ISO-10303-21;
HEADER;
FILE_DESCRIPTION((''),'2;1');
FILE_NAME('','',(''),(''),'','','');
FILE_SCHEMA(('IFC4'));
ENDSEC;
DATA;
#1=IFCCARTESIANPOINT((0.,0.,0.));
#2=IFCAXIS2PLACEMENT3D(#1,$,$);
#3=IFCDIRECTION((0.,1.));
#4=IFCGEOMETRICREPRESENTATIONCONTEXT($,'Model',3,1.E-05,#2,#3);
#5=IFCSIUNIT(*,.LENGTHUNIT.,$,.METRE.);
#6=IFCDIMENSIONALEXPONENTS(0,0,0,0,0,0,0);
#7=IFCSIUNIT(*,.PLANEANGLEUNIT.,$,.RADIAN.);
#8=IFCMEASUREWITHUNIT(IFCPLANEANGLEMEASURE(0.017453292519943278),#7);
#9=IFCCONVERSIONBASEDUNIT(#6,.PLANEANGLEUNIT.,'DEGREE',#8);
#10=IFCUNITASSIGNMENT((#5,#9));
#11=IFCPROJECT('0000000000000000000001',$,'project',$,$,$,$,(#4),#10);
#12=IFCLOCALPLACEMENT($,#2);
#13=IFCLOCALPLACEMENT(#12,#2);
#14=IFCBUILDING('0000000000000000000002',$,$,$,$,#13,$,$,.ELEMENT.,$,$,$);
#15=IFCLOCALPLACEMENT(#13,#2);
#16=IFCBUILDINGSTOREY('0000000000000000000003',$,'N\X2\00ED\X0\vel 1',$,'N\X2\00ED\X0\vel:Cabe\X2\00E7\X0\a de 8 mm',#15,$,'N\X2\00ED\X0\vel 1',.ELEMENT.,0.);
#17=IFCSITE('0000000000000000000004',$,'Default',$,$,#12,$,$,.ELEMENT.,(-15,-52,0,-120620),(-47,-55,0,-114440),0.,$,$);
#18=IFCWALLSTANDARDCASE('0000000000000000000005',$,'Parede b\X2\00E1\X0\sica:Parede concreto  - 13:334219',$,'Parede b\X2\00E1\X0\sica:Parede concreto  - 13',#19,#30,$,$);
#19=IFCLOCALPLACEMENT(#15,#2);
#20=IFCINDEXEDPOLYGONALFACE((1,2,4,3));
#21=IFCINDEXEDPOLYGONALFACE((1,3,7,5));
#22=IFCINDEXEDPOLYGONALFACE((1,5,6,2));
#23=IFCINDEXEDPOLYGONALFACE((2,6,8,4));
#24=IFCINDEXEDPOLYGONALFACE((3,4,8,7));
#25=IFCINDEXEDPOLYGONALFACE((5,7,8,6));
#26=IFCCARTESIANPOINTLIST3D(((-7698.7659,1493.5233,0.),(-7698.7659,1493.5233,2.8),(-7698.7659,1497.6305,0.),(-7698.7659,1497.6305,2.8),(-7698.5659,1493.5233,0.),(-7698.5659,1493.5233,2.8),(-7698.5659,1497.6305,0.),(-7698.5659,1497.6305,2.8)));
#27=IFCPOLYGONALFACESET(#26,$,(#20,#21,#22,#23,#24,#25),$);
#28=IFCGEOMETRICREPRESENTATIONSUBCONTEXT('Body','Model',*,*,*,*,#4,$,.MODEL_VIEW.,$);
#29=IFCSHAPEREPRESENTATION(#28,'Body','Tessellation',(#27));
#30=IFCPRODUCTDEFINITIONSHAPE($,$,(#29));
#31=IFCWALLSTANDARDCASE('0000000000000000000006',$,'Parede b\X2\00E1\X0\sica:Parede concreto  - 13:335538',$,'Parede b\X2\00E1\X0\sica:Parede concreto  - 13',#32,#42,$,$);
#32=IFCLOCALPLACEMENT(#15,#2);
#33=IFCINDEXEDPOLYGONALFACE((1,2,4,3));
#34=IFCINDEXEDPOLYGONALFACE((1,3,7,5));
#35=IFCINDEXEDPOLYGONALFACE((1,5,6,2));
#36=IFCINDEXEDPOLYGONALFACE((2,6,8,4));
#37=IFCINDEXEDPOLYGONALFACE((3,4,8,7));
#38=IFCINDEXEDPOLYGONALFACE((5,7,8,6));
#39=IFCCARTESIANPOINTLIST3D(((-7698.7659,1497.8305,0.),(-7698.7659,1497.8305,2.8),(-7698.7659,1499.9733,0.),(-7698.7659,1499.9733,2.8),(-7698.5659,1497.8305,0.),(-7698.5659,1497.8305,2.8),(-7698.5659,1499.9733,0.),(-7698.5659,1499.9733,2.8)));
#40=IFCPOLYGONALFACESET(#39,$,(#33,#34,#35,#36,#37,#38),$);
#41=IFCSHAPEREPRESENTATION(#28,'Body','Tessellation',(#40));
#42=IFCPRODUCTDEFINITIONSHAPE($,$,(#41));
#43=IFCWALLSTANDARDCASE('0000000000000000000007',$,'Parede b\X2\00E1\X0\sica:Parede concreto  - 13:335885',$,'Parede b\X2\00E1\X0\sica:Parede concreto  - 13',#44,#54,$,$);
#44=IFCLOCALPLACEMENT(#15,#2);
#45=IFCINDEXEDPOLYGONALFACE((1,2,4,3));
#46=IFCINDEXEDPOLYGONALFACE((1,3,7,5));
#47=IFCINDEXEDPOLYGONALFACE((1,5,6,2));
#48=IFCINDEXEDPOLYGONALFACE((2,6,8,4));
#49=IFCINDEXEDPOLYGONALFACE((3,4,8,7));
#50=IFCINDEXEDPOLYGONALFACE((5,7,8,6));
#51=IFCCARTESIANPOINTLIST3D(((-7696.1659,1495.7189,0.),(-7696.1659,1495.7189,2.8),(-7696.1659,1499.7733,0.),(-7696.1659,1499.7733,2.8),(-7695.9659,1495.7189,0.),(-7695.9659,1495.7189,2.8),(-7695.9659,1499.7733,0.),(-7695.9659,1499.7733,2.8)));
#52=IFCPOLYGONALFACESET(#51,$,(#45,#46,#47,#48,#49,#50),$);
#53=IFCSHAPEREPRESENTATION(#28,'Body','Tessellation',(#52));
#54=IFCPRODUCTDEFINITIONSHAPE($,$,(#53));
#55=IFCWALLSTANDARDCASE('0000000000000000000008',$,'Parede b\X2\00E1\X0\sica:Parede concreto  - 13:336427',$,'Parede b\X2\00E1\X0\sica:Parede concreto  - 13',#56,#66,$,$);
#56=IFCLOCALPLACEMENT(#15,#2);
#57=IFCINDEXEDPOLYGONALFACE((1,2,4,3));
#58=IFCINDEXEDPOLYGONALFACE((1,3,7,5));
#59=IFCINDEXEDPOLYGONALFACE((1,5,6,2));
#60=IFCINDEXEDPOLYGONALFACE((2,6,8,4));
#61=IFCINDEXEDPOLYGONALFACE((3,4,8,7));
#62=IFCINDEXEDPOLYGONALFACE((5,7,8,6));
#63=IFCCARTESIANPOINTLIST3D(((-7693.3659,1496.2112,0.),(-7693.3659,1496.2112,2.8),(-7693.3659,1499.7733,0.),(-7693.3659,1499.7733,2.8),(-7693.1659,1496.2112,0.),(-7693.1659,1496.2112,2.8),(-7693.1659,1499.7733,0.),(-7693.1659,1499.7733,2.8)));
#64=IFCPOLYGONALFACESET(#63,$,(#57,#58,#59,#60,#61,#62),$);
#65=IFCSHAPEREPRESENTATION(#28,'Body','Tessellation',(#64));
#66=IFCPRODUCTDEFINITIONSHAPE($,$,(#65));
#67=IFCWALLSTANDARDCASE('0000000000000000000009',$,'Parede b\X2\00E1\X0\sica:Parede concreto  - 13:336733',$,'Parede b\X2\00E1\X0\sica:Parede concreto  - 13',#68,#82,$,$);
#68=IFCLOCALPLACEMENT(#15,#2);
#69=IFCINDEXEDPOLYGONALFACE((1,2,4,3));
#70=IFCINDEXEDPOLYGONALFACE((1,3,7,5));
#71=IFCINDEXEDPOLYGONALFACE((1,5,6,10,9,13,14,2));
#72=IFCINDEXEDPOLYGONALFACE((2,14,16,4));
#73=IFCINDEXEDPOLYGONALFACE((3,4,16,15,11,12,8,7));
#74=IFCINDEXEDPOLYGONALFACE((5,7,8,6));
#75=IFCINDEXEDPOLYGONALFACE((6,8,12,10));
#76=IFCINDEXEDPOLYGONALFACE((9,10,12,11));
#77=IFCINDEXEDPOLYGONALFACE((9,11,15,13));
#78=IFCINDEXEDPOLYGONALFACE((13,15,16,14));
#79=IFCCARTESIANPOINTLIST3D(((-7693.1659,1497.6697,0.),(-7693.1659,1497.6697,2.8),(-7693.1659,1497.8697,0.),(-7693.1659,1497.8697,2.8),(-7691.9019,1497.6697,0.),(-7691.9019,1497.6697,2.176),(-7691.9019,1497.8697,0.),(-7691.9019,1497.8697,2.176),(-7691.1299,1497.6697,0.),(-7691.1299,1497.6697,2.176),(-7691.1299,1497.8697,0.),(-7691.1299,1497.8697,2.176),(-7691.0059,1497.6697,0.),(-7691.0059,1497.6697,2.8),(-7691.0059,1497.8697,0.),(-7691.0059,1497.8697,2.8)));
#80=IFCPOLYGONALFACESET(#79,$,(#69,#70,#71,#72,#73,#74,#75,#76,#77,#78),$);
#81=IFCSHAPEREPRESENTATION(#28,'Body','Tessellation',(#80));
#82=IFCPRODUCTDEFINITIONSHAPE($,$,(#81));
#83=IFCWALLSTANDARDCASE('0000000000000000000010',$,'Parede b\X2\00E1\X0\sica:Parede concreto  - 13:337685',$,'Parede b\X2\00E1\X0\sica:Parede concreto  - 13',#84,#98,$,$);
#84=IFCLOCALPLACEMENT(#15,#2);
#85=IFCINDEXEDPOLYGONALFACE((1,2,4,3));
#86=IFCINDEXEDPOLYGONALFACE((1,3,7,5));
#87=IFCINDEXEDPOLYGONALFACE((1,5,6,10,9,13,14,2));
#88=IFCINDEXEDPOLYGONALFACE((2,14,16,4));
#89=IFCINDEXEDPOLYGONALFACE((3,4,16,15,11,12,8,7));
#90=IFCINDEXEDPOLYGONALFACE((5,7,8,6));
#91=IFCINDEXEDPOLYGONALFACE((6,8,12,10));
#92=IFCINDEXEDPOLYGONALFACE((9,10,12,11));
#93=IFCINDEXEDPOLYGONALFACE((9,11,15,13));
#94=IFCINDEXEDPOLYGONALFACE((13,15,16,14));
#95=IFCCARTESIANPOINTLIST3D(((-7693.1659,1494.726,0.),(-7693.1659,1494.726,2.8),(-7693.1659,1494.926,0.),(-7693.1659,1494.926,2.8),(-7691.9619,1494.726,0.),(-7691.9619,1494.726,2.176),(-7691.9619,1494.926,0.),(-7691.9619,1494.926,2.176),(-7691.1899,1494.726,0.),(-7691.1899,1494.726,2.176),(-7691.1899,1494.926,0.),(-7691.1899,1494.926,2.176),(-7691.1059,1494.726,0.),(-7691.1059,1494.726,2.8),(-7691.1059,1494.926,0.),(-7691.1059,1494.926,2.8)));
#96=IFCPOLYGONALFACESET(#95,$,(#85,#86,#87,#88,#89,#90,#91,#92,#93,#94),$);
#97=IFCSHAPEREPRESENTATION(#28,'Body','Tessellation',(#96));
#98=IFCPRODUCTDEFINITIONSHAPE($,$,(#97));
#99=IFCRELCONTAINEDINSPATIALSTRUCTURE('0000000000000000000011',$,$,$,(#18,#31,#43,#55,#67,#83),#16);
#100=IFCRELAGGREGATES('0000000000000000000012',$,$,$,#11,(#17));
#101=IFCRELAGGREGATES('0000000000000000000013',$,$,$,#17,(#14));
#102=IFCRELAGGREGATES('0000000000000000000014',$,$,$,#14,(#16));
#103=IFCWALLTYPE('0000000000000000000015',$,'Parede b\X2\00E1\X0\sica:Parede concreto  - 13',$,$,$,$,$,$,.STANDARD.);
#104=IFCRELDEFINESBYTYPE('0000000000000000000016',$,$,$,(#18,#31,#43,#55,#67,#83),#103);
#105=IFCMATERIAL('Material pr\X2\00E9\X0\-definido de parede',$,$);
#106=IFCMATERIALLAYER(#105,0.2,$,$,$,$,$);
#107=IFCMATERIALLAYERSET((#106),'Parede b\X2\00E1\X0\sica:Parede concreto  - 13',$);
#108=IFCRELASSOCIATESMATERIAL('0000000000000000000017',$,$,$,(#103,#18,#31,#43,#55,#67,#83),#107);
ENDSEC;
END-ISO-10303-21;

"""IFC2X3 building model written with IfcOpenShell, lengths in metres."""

from ifc_helpers import new_model, entity, si_unit, converted_unit, direction, frame, frame_2d, origin, place, context, subcontext, project, spatial, rectangle, extrude, material, layer, layer_set, layer_usage, type_object, element, save


model = new_model("IFC2X3")

# Units and contexts
model_context = context("Model", 3, precision=1e-05, world=origin(), true_north=direction((0.0, 1.0)))
body_context = subcontext(model_context, "Body", "Model", "MODEL_VIEW")
ifc_project = project(units=[si_unit("LENGTHUNIT", "METRE"), converted_unit("PLANEANGLEUNIT", "DEGREE", entity("IfcPlaneAngleMeasure", 0.017453292519943278), si_unit("PLANEANGLEUNIT", "RADIAN"), dimensions=[0, 0, 0, 0, 0, 0, 0])], contexts=[model_context])

# Site, building, storey
site_placement = place(None, origin())
site = spatial("IfcSite", under=ifc_project, at=site_placement, Name="Default", CompositionType="ELEMENT", RefLatitude=(-15, -52, 0, -120620), RefLongitude=(-47, -55, 0, -114440), RefElevation=0.0)
building_placement = place(site_placement, origin())
building = spatial("IfcBuilding", under=site, at=building_placement, CompositionType="ELEMENT")
storey_placement = place(building_placement, origin())
storey = spatial("IfcBuildingStorey", under=building, at=storey_placement, Name="Nível 1", ObjectType="Nível:Cabeça de 8 mm", LongName="Nível 1", CompositionType="ELEMENT", Elevation=0.0)

# Shared definitions
ifc_material_1 = material(Name="Material pré-definido de parede")
ifc_layer = layer(ifc_material_1, 0.2)
ifc_layer_set = layer_set([ifc_layer], Name="Parede básica:Parede concreto  - 13")
wall_type = type_object("IfcWallType", Name="Parede básica:Parede concreto  - 13", PredefinedType="STANDARD", material=ifc_layer_set)

# Walls
ifc_layer_usage_1 = layer_usage(ifc_layer_set, "AXIS2", "NEGATIVE", 0.1)
wall_1_placement = place(storey_placement, frame((-7698.6659, 1497.6305, 0.0), z_axis=(0.0, 0.0, 1.0), x_axis=(0.0, -1.0, 0.0)))
element("IfcWallStandardCase", 1, at=wall_1_placement, inside=storey, type_object=wall_type, material=ifc_layer_usage_1, Name="Parede básica:Parede concreto  - 13:334219", ObjectType="Parede básica:Parede concreto  - 13", context=body_context, shape_type="SweptSolid", body=[
    extrude(rectangle(XDim=4.1072, YDim=0.2, at=frame_2d((2.0536, 0.0), x_axis=(-1.0, 0.0))), origin(), (0.0, 0.0, 1.0), 2.8),
])
ifc_layer_usage_2 = layer_usage(ifc_layer_set, "AXIS2", "NEGATIVE", 0.1)
wall_2_placement = place(storey_placement, frame((-7698.6659, 1497.8305, 0.0), z_axis=(0.0, 0.0, 1.0), x_axis=(0.0, 1.0, 0.0)))
element("IfcWallStandardCase", 2, at=wall_2_placement, inside=storey, type_object=wall_type, material=ifc_layer_usage_2, Name="Parede básica:Parede concreto  - 13:335538", ObjectType="Parede básica:Parede concreto  - 13", context=body_context, shape_type="SweptSolid", body=[
    extrude(rectangle(XDim=2.1428, YDim=0.2, at=frame_2d((1.0714, 0.0), x_axis=(-1.0, 0.0))), origin(), (0.0, 0.0, 1.0), 2.8),
])
ifc_layer_usage_3 = layer_usage(ifc_layer_set, "AXIS2", "NEGATIVE", 0.1)
wall_3_placement = place(storey_placement, frame((-7696.0659, 1499.7733, 0.0), z_axis=(0.0, 0.0, 1.0), x_axis=(0.0, -1.0, 0.0)))
element("IfcWallStandardCase", 3, at=wall_3_placement, inside=storey, type_object=wall_type, material=ifc_layer_usage_3, Name="Parede básica:Parede concreto  - 13:335885", ObjectType="Parede básica:Parede concreto  - 13", context=body_context, shape_type="SweptSolid", body=[
    extrude(rectangle(XDim=4.0544, YDim=0.2, at=frame_2d((2.0272, 0.0), x_axis=(-1.0, 0.0))), origin(), (0.0, 0.0, 1.0), 2.8),
])
ifc_layer_usage_4 = layer_usage(ifc_layer_set, "AXIS2", "NEGATIVE", 0.1)
wall_4_placement = place(storey_placement, frame((-7693.2659, 1499.7733, 0.0), z_axis=(0.0, 0.0, 1.0), x_axis=(0.0, -1.0, 0.0)))
element("IfcWallStandardCase", 4, at=wall_4_placement, inside=storey, type_object=wall_type, material=ifc_layer_usage_4, Name="Parede básica:Parede concreto  - 13:336427", ObjectType="Parede básica:Parede concreto  - 13", context=body_context, shape_type="SweptSolid", body=[
    extrude(rectangle(XDim=3.5621, YDim=0.2, at=frame_2d((1.7811, 0.0), x_axis=(-1.0, 0.0))), origin(), (0.0, 0.0, 1.0), 2.8),
])

# Walls, openings
ifc_layer_usage_5 = layer_usage(ifc_layer_set, "AXIS2", "NEGATIVE", 0.1)
wall_5_placement = place(storey_placement, frame((-7693.1659, 1497.7697, 0.0)))
wall_5 = element("IfcWallStandardCase", 5, at=wall_5_placement, inside=storey, type_object=wall_type, material=ifc_layer_usage_5, Name="Parede básica:Parede concreto  - 13:336733", ObjectType="Parede básica:Parede concreto  - 13", context=body_context, shape_type="SweptSolid", body=[
    extrude(rectangle(XDim=2.16, YDim=0.2, at=frame_2d((1.08, 0.0), x_axis=(-1.0, 0.0))), origin(), (0.0, 0.0, 1.0), 2.8),
])
opening_1_placement = place(wall_5_placement, origin())
element("IfcOpeningElement", 6, at=opening_1_placement, cuts=wall_5, ObjectType="Opening", context=body_context, shape_type="SweptSolid", body=[
    extrude(rectangle(XDim=2.176, YDim=0.772, at=frame_2d((0.0, 0.0), x_axis=(0.0, 1.0))), frame((1.65, 0.1, 1.088), z_axis=(0.0, -1.0, 0.0), x_axis=(1.0, 0.0, 0.0)), (0.0, 0.0, 1.0), 0.2),
])
ifc_layer_usage_6 = layer_usage(ifc_layer_set, "AXIS2", "NEGATIVE", 0.1)
wall_6_placement = place(storey_placement, frame((-7693.1659, 1494.826, 0.0)))
wall_6 = element("IfcWallStandardCase", 7, at=wall_6_placement, inside=storey, type_object=wall_type, material=ifc_layer_usage_6, Name="Parede básica:Parede concreto  - 13:337685", ObjectType="Parede básica:Parede concreto  - 13", context=body_context, shape_type="SweptSolid", body=[
    extrude(rectangle(XDim=2.06, YDim=0.2, at=frame_2d((1.03, 0.0), x_axis=(-1.0, 0.0))), origin(), (0.0, 0.0, 1.0), 2.8),
])
opening_2_placement = place(wall_6_placement, origin())
element("IfcOpeningElement", 8, at=opening_2_placement, cuts=wall_6, ObjectType="Opening", context=body_context, shape_type="SweptSolid", body=[
    extrude(rectangle(XDim=2.176, YDim=0.772, at=frame_2d((0.0, 0.0), x_axis=(0.0, 1.0))), frame((1.59, 0.1, 1.088), z_axis=(0.0, -1.0, 0.0), x_axis=(1.0, 0.0, 0.0)), (0.0, 0.0, 1.0), 0.2),
])

save(model, "model.ifc")
